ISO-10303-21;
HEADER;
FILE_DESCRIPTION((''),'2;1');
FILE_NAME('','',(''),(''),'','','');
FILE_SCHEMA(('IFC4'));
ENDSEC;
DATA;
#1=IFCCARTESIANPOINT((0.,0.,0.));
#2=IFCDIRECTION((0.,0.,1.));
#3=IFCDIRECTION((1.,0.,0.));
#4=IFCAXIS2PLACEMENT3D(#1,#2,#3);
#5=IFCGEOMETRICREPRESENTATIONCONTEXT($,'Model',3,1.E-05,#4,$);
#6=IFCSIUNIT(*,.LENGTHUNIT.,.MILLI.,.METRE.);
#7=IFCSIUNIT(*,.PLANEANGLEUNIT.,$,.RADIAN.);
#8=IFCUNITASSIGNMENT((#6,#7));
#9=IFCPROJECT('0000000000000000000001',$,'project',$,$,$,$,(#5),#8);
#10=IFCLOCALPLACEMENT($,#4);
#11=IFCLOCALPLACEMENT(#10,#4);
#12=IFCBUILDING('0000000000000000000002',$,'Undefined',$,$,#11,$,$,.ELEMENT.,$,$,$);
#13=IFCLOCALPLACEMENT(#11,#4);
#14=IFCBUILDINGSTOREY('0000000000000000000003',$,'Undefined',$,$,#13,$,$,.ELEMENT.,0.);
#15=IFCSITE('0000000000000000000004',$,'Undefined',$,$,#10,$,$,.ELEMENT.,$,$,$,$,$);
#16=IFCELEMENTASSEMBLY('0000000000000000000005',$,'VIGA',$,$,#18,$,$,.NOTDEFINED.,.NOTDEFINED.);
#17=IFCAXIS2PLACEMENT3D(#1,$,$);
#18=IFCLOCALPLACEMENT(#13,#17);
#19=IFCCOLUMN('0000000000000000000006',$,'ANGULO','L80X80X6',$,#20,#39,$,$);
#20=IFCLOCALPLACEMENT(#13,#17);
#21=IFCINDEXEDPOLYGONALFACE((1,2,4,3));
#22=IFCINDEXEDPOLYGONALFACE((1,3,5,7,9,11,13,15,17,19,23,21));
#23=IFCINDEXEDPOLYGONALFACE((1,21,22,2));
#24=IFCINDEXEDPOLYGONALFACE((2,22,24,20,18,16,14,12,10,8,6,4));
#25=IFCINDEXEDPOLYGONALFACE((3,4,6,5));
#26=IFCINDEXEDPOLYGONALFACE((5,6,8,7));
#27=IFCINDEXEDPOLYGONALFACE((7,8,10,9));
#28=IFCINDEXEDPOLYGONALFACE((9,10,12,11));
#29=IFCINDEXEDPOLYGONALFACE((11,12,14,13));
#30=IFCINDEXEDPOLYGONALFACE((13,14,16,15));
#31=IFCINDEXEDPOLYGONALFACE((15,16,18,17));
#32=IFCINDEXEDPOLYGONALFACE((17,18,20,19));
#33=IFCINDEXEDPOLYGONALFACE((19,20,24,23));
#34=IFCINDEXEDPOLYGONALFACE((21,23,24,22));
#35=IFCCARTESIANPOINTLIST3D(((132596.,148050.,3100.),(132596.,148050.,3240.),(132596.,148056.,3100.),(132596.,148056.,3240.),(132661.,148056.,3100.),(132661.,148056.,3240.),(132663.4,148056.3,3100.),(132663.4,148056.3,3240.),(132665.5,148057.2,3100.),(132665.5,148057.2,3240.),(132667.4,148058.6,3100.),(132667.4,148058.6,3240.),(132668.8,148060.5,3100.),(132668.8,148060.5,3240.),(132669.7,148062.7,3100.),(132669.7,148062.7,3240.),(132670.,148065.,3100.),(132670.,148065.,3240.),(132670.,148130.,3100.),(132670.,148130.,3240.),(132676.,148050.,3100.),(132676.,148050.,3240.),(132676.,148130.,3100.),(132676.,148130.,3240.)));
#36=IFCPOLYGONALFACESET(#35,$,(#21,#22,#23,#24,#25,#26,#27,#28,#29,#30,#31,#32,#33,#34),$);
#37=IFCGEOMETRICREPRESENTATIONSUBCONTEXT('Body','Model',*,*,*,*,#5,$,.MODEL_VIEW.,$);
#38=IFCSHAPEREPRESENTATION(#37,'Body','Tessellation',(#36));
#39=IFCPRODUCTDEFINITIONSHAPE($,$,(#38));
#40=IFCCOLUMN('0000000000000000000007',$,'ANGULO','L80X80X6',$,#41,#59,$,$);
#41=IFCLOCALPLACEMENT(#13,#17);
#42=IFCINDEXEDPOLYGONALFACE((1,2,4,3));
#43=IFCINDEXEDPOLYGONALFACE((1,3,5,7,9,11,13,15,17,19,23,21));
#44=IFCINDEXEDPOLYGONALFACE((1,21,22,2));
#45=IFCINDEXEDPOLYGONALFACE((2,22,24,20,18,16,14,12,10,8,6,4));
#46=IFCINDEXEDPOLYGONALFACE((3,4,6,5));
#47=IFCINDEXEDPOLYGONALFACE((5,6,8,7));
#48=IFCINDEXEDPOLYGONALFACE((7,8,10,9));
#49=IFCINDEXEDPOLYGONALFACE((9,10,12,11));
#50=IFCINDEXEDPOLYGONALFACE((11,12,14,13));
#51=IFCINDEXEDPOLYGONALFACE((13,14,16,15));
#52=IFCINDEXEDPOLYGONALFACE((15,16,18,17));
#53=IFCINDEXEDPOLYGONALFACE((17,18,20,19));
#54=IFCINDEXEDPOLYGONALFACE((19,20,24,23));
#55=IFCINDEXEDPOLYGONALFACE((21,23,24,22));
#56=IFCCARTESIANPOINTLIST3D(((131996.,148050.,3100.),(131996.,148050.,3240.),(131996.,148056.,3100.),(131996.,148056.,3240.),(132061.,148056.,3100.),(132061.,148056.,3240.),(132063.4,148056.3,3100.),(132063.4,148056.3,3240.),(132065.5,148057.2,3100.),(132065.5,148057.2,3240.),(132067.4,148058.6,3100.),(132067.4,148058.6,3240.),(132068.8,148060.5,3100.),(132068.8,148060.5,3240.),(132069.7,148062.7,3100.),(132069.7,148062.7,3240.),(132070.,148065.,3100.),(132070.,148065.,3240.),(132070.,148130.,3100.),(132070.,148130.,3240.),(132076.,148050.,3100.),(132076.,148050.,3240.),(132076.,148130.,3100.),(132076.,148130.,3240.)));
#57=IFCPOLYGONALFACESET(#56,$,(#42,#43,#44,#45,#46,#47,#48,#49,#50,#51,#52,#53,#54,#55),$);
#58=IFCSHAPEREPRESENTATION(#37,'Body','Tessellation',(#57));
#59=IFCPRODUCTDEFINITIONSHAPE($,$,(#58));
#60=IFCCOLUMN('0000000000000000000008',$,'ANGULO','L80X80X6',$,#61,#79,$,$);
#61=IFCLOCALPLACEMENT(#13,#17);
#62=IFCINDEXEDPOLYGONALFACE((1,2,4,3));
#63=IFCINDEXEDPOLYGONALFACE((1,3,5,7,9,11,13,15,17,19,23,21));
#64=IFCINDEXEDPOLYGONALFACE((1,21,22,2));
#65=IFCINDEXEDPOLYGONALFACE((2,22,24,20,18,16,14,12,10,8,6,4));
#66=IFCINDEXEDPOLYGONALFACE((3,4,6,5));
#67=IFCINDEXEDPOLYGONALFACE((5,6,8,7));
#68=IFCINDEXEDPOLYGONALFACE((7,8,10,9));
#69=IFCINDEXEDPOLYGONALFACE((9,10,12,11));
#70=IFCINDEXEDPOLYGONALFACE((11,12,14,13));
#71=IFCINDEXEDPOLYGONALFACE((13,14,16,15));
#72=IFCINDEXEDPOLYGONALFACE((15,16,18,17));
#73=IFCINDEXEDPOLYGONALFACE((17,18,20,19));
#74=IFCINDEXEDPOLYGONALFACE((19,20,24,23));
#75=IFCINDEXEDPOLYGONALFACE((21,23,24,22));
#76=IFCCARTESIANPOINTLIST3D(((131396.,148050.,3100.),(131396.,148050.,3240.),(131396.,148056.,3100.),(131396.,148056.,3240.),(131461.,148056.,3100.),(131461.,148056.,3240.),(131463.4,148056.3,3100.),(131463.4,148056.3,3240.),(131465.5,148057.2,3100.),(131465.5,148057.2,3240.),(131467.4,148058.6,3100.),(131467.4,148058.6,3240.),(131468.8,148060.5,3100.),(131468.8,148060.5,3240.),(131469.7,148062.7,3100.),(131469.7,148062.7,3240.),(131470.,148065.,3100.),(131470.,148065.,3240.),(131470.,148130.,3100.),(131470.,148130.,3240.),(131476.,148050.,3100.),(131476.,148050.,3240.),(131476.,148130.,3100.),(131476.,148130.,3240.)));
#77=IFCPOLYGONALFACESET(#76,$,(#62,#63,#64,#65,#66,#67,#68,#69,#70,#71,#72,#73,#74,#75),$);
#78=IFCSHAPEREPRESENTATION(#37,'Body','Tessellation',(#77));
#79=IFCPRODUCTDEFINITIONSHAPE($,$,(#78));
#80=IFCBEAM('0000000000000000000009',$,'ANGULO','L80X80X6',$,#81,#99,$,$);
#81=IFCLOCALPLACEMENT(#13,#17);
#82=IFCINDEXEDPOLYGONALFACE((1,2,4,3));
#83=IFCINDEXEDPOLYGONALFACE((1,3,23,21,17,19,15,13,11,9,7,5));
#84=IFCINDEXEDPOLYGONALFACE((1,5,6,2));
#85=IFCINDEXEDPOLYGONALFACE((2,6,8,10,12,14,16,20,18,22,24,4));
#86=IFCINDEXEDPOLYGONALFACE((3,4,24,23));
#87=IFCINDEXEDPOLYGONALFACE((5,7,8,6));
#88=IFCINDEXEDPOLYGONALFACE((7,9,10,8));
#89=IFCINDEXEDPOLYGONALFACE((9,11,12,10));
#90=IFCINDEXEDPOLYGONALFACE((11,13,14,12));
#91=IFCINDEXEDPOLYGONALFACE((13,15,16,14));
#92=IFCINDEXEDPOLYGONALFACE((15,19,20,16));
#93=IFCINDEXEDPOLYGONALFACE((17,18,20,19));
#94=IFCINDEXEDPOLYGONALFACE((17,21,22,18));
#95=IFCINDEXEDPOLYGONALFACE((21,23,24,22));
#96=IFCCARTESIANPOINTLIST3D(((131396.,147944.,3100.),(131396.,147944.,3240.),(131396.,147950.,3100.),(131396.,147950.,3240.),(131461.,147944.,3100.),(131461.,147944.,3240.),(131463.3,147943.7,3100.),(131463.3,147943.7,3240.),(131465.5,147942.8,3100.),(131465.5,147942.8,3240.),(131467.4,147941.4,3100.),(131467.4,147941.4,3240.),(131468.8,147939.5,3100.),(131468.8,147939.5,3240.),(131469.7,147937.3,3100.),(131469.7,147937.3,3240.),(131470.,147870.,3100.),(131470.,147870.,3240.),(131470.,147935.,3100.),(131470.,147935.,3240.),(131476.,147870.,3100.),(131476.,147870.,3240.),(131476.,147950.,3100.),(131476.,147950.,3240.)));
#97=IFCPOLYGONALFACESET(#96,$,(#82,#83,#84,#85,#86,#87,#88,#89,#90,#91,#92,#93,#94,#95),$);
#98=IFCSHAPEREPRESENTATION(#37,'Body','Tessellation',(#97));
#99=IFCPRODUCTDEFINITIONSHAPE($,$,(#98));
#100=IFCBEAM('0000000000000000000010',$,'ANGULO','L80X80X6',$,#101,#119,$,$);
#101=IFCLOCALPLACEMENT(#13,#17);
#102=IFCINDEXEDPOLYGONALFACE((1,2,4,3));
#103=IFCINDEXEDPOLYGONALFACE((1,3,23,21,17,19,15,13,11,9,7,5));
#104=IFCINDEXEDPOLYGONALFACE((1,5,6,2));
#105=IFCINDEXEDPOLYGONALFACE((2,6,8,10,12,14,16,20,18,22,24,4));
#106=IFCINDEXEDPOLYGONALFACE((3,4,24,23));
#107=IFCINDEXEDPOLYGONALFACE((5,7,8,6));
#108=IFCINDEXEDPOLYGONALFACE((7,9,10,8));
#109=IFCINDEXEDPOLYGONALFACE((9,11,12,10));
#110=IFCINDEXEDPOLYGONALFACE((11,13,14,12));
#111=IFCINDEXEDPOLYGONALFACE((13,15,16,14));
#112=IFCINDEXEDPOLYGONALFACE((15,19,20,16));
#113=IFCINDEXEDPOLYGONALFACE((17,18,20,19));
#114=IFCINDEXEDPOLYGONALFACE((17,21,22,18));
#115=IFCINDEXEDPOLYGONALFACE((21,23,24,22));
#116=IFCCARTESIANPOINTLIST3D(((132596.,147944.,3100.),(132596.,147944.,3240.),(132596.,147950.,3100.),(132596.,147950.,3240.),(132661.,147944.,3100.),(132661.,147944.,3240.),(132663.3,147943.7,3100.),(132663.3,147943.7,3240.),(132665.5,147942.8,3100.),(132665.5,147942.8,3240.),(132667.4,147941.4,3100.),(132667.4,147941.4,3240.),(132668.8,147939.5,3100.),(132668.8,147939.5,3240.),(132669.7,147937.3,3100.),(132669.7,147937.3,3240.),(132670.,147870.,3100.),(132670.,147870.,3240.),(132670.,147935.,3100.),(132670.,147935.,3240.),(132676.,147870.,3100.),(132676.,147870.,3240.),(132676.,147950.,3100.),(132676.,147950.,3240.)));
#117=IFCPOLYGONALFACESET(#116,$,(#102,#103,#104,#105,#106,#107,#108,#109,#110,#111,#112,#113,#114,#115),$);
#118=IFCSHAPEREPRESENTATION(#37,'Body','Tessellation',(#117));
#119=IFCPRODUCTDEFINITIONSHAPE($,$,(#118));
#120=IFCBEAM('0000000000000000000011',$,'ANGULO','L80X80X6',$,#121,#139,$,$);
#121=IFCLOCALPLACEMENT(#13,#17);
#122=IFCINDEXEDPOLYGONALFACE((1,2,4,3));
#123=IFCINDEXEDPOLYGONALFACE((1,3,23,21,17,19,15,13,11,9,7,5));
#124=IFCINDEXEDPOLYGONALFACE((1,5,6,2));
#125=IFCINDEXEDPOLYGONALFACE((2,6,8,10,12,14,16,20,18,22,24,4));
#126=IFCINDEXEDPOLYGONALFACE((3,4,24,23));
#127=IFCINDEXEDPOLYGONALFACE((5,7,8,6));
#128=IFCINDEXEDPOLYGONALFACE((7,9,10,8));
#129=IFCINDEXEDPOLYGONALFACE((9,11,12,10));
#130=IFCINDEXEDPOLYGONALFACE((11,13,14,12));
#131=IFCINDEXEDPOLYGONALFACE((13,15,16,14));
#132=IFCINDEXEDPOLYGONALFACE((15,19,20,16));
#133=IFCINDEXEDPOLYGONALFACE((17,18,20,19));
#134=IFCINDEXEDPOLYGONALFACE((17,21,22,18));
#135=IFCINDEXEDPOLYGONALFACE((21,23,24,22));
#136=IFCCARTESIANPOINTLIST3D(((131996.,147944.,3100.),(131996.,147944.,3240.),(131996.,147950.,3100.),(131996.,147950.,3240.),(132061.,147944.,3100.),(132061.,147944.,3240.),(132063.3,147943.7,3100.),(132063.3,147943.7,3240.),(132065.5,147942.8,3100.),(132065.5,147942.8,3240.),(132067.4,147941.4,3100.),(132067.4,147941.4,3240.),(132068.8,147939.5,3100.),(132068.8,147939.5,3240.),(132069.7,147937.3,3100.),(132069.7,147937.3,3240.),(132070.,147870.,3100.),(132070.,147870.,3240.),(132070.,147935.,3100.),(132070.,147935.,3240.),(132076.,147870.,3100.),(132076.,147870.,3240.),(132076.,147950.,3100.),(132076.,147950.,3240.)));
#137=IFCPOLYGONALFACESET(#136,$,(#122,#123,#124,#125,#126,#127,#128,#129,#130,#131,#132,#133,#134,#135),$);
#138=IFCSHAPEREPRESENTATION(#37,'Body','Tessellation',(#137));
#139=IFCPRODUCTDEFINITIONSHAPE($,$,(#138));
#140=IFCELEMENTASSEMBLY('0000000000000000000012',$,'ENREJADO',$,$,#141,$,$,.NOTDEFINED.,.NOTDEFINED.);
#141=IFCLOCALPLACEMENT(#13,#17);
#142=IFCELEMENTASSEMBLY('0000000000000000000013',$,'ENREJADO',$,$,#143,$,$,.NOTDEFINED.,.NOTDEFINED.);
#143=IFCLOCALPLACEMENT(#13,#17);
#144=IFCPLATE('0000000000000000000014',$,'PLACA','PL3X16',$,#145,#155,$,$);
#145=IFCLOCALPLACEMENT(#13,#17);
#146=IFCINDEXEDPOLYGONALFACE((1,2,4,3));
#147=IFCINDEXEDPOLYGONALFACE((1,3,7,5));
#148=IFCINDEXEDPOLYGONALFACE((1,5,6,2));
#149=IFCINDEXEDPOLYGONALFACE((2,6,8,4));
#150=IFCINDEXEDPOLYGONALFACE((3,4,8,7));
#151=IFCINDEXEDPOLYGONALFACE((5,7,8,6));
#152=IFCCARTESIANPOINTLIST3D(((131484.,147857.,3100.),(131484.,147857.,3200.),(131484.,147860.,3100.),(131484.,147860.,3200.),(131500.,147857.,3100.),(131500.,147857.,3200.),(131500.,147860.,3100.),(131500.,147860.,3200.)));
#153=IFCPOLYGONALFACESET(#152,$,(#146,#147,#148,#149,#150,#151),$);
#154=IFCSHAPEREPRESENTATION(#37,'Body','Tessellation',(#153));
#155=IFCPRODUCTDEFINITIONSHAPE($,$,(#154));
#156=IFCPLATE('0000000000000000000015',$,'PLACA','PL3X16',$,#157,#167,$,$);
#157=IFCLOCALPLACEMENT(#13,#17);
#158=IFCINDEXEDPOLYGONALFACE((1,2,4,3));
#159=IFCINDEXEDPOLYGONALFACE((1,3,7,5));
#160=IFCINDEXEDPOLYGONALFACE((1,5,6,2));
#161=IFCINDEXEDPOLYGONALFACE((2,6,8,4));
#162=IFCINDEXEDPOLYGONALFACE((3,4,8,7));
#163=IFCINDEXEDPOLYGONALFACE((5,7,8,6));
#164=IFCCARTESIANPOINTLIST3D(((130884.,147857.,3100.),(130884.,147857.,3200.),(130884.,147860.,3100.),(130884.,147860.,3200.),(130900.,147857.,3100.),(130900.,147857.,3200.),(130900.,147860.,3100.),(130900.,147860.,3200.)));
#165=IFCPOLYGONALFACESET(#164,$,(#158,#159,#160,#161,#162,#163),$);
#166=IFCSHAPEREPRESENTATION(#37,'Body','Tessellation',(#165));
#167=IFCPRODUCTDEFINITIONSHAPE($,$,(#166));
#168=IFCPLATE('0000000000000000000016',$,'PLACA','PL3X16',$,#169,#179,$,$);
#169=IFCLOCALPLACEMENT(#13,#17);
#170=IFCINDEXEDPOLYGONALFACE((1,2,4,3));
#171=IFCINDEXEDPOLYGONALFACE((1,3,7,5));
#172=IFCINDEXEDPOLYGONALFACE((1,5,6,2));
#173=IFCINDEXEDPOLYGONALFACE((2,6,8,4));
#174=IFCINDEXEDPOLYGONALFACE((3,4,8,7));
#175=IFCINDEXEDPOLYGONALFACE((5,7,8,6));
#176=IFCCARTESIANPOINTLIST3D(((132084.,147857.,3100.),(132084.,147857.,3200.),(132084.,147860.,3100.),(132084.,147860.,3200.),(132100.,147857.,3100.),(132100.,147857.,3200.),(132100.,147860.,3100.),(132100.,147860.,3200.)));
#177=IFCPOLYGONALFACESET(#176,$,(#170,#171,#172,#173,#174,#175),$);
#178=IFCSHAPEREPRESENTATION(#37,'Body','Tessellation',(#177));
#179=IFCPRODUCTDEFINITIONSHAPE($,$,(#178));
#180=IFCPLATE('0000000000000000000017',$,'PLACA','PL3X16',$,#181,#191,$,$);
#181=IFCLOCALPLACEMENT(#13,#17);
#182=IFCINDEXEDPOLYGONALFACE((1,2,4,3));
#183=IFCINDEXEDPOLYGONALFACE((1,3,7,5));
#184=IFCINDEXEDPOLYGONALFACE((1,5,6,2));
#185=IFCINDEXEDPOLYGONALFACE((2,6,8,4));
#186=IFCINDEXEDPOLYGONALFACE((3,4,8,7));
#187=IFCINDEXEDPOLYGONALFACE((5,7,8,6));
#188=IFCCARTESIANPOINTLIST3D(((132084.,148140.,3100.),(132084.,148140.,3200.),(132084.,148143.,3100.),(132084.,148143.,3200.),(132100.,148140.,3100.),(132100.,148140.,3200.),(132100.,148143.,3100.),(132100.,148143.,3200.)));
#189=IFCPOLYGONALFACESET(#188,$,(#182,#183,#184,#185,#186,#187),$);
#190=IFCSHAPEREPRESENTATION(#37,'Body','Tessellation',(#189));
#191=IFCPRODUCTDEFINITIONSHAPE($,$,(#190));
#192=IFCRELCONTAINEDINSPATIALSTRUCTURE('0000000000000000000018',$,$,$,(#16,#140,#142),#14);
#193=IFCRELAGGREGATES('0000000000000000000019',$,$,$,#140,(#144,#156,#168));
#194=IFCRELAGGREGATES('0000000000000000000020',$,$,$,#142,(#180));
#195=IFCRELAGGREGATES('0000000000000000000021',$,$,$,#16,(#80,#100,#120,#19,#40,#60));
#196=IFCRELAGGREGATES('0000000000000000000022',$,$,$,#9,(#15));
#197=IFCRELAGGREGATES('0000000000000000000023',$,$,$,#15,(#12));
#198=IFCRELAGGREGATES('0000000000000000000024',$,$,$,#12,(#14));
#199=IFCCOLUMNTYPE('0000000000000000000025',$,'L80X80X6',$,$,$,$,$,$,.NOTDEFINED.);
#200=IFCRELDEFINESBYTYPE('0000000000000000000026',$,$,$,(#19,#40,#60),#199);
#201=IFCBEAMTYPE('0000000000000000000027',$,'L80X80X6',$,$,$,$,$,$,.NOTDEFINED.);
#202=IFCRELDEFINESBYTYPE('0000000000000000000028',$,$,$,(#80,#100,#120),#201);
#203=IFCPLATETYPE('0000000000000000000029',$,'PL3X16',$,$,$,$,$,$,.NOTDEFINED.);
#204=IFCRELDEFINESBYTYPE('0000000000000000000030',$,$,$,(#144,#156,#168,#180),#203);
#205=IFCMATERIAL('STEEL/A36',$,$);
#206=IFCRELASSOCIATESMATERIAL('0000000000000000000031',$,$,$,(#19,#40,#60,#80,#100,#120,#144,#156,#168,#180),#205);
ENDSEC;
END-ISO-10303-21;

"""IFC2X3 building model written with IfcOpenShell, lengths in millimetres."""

from ifc_helpers import new_model, si_unit, frame, origin_with_axes, origin_2d_with_axis, place, context, subcontext, project, spatial, polyline, l_section, outline, extrude, material, type_object, element, aggregate, save


model = new_model("IFC2X3")

# Units and contexts
model_context = context("Model", 3, precision=1e-05, world=origin_with_axes())
body_context = subcontext(model_context, "Body", "Model", "MODEL_VIEW")
ifc_project = project(units=[si_unit("LENGTHUNIT", "METRE", prefix="MILLI"), si_unit("PLANEANGLEUNIT", "RADIAN")], contexts=[model_context])

# Site, building, storey
site_placement = place(None, origin_with_axes())
site = spatial("IfcSite", under=ifc_project, at=site_placement, Name="Undefined", CompositionType="ELEMENT")
building_placement = place(site_placement, origin_with_axes())
building = spatial("IfcBuilding", under=site, at=building_placement, Name="Undefined", CompositionType="ELEMENT")
storey_placement = place(building_placement, origin_with_axes())
storey = spatial("IfcBuildingStorey", under=building, at=storey_placement, Name="Undefined", CompositionType="ELEMENT", Elevation=0.0)

# Element assembly, columns, beams
assembly_1_placement = place(storey_placement, origin_with_axes())
assembly_1 = element("IfcElementAssembly", 1, at=assembly_1_placement, inside=storey, Name="VIGA", AssemblyPlace="NOTDEFINED", PredefinedType="NOTDEFINED")
ifc_material_1 = material(Name="STEEL/A36")
column_type = type_object("IfcColumnType", Name="L80X80X6", PredefinedType="NOTDEFINED")
column_1_placement = place(assembly_1_placement, frame((132636.0, 148090.0, 3100.0), z_axis=(0.0, 0.0, 1.0), x_axis=(0.0, 1.0, 0.0)))
column_1 = element("IfcColumn", 2, at=column_1_placement, type_object=column_type, material=ifc_material_1, Name="ANGULO", Description="L80X80X6", context=body_context, shape_type="SweptSolid", body=[
    extrude(l_section(Depth=80.0, Width=80.0, Thickness=6.0, FilletRadius=9.0, at=origin_2d_with_axis()), frame((0.0, 0.0, 140.0), z_axis=(0.0, 0.0, -1.0), x_axis=(0.0, 1.0, 0.0)), (0.0, 0.0, 1.0), 140.0),
])
column_2_placement = place(assembly_1_placement, frame((132036.0, 148090.0, 3100.0), z_axis=(0.0, 0.0, 1.0), x_axis=(0.0, 1.0, 0.0)))
column_2 = element("IfcColumn", 3, at=column_2_placement, type_object=column_type, material=ifc_material_1, Name="ANGULO", Description="L80X80X6", context=body_context, shape_type="SweptSolid", body=[
    extrude(l_section(Depth=80.0, Width=80.0, Thickness=6.0, FilletRadius=9.0, at=origin_2d_with_axis()), frame((0.0, 0.0, 140.0), z_axis=(0.0, 0.0, -1.0), x_axis=(0.0, 1.0, 0.0)), (0.0, 0.0, 1.0), 140.0),
])
column_3_placement = place(assembly_1_placement, frame((131436.0, 148090.0, 3100.0), z_axis=(0.0, 0.0, 1.0), x_axis=(0.0, 1.0, 0.0)))
column_3 = element("IfcColumn", 4, at=column_3_placement, type_object=column_type, material=ifc_material_1, Name="ANGULO", Description="L80X80X6", context=body_context, shape_type="SweptSolid", body=[
    extrude(l_section(Depth=80.0, Width=80.0, Thickness=6.0, FilletRadius=9.0, at=origin_2d_with_axis()), frame((0.0, 0.0, 140.0), z_axis=(0.0, 0.0, -1.0), x_axis=(0.0, 1.0, 0.0)), (0.0, 0.0, 1.0), 140.0),
])
beam_type_1 = type_object("IfcBeamType", Name="L80X80X6", PredefinedType="NOTDEFINED")
beam_1_placement = place(assembly_1_placement, frame((131436.0, 147910.0, 3240.0), z_axis=(0.0, -1.0, 0.0), x_axis=(0.0, 0.0, -1.0)))
beam_1 = element("IfcBeam", 5, at=beam_1_placement, type_object=beam_type_1, material=ifc_material_1, Name="ANGULO", Description="L80X80X6", context=body_context, shape_type="SweptSolid", body=[
    extrude(l_section(Depth=80.0, Width=80.0, Thickness=6.0, FilletRadius=9.0, at=origin_2d_with_axis()), frame((140.0, 0.0, 0.0), z_axis=(-1.0, 0.0, 0.0), x_axis=(0.0, -1.0, 0.0)), (0.0, 0.0, 1.0), 140.0),
])
beam_2_placement = place(assembly_1_placement, frame((132636.0, 147910.0, 3240.0), z_axis=(0.0, -1.0, 0.0), x_axis=(0.0, 0.0, -1.0)))
beam_2 = element("IfcBeam", 6, at=beam_2_placement, type_object=beam_type_1, material=ifc_material_1, Name="ANGULO", Description="L80X80X6", context=body_context, shape_type="SweptSolid", body=[
    extrude(l_section(Depth=80.0, Width=80.0, Thickness=6.0, FilletRadius=9.0, at=origin_2d_with_axis()), frame((140.0, 0.0, 0.0), z_axis=(-1.0, 0.0, 0.0), x_axis=(0.0, -1.0, 0.0)), (0.0, 0.0, 1.0), 140.0),
])
beam_3_placement = place(assembly_1_placement, frame((132036.0, 147910.0, 3240.0), z_axis=(0.0, -1.0, 0.0), x_axis=(0.0, 0.0, -1.0)))
beam_3 = element("IfcBeam", 7, at=beam_3_placement, type_object=beam_type_1, material=ifc_material_1, Name="ANGULO", Description="L80X80X6", context=body_context, shape_type="SweptSolid", body=[
    extrude(l_section(Depth=80.0, Width=80.0, Thickness=6.0, FilletRadius=9.0, at=origin_2d_with_axis()), frame((140.0, 0.0, 0.0), z_axis=(-1.0, 0.0, 0.0), x_axis=(0.0, -1.0, 0.0)), (0.0, 0.0, 1.0), 140.0),
])

# Element assembly
assembly_2_placement = place(storey_placement, origin_with_axes())
assembly_2 = element("IfcElementAssembly", 8, at=assembly_2_placement, inside=storey, Name="ENREJADO", AssemblyPlace="NOTDEFINED", PredefinedType="NOTDEFINED")

# Element assembly
assembly_3_placement = place(storey_placement, origin_with_axes())
assembly_3 = element("IfcElementAssembly", 9, at=assembly_3_placement, inside=storey, Name="ENREJADO", AssemblyPlace="NOTDEFINED", PredefinedType="NOTDEFINED")

# Plates
plate_type_1 = type_object("IfcPlateType", Name="PL3X16", PredefinedType="NOTDEFINED")
plate_1_placement = place(assembly_2_placement, frame((131500.0, 147858.5, 3200.0), z_axis=(0.000001, -1.0, 0.0), x_axis=(-1.0, -0.000001, 0.0)))
plate_1 = element("IfcPlate", 10, at=plate_1_placement, type_object=plate_type_1, material=ifc_material_1, Name="PLACA", Description="PL3X16", context=body_context, shape_type="SweptSolid", body=[
    extrude(outline(polyline([(0.0, 0.0), (16.0, 0.0), (16.0, 100.0), (0.0, 100.0), (0.0, 0.0)])), frame((0.0, 0.0, -1.5), z_axis=(0.0, 0.0, 1.0), x_axis=(1.0, 0.0, 0.0)), (0.0, 0.0, 1.0), 3.0),
])
plate_2_placement = place(assembly_2_placement, frame((130900.0, 147858.5, 3200.0), z_axis=(0.000001, -1.0, 0.0), x_axis=(-1.0, -0.000001, 0.0)))
plate_2 = element("IfcPlate", 11, at=plate_2_placement, type_object=plate_type_1, material=ifc_material_1, Name="PLACA", Description="PL3X16", context=body_context, shape_type="SweptSolid", body=[
    extrude(outline(polyline([(0.0, 0.0), (16.0, 0.0), (16.0, 100.0), (0.0, 100.0), (0.0, 0.0)])), frame((0.0, 0.0, -1.5), z_axis=(0.0, 0.0, 1.0), x_axis=(1.0, 0.0, 0.0)), (0.0, 0.0, 1.0), 3.0),
])
plate_3_placement = place(assembly_2_placement, frame((132100.0, 147858.5, 3200.0), z_axis=(0.000001, -1.0, 0.0), x_axis=(-1.0, -0.000001, 0.0)))
plate_3 = element("IfcPlate", 12, at=plate_3_placement, type_object=plate_type_1, material=ifc_material_1, Name="PLACA", Description="PL3X16", context=body_context, shape_type="SweptSolid", body=[
    extrude(outline(polyline([(0.0, 0.0), (16.0, 0.0), (16.0, 100.0), (0.0, 100.0), (0.0, 0.0)])), frame((0.0, 0.0, -1.5), z_axis=(0.0, 0.0, 1.0), x_axis=(1.0, 0.0, 0.0)), (0.0, 0.0, 1.0), 3.0),
])
plate_4_placement = place(assembly_3_placement, frame((132100.0, 148141.5, 3100.0), z_axis=(0.000001, 1.0, 0.0), x_axis=(-1.0, 0.000001, 0.0)))
plate_4 = element("IfcPlate", 13, at=plate_4_placement, type_object=plate_type_1, material=ifc_material_1, Name="PLACA", Description="PL3X16", context=body_context, shape_type="SweptSolid", body=[
    extrude(outline(polyline([(0.0, 0.0), (16.0, 0.0), (16.0, 100.0), (0.0, 100.0), (0.0, 0.0)])), frame((0.0, 0.0, -1.5), z_axis=(0.0, 0.0, 1.0), x_axis=(1.0, 0.0, 0.0)), (0.0, 0.0, 1.0), 3.0),
])

aggregate(assembly_2, [plate_1, plate_2, plate_3])
aggregate(assembly_3, [plate_4])

aggregate(assembly_1, [beam_1, beam_2, beam_3, column_1, column_2, column_3])

save(model, "model.ifc")
